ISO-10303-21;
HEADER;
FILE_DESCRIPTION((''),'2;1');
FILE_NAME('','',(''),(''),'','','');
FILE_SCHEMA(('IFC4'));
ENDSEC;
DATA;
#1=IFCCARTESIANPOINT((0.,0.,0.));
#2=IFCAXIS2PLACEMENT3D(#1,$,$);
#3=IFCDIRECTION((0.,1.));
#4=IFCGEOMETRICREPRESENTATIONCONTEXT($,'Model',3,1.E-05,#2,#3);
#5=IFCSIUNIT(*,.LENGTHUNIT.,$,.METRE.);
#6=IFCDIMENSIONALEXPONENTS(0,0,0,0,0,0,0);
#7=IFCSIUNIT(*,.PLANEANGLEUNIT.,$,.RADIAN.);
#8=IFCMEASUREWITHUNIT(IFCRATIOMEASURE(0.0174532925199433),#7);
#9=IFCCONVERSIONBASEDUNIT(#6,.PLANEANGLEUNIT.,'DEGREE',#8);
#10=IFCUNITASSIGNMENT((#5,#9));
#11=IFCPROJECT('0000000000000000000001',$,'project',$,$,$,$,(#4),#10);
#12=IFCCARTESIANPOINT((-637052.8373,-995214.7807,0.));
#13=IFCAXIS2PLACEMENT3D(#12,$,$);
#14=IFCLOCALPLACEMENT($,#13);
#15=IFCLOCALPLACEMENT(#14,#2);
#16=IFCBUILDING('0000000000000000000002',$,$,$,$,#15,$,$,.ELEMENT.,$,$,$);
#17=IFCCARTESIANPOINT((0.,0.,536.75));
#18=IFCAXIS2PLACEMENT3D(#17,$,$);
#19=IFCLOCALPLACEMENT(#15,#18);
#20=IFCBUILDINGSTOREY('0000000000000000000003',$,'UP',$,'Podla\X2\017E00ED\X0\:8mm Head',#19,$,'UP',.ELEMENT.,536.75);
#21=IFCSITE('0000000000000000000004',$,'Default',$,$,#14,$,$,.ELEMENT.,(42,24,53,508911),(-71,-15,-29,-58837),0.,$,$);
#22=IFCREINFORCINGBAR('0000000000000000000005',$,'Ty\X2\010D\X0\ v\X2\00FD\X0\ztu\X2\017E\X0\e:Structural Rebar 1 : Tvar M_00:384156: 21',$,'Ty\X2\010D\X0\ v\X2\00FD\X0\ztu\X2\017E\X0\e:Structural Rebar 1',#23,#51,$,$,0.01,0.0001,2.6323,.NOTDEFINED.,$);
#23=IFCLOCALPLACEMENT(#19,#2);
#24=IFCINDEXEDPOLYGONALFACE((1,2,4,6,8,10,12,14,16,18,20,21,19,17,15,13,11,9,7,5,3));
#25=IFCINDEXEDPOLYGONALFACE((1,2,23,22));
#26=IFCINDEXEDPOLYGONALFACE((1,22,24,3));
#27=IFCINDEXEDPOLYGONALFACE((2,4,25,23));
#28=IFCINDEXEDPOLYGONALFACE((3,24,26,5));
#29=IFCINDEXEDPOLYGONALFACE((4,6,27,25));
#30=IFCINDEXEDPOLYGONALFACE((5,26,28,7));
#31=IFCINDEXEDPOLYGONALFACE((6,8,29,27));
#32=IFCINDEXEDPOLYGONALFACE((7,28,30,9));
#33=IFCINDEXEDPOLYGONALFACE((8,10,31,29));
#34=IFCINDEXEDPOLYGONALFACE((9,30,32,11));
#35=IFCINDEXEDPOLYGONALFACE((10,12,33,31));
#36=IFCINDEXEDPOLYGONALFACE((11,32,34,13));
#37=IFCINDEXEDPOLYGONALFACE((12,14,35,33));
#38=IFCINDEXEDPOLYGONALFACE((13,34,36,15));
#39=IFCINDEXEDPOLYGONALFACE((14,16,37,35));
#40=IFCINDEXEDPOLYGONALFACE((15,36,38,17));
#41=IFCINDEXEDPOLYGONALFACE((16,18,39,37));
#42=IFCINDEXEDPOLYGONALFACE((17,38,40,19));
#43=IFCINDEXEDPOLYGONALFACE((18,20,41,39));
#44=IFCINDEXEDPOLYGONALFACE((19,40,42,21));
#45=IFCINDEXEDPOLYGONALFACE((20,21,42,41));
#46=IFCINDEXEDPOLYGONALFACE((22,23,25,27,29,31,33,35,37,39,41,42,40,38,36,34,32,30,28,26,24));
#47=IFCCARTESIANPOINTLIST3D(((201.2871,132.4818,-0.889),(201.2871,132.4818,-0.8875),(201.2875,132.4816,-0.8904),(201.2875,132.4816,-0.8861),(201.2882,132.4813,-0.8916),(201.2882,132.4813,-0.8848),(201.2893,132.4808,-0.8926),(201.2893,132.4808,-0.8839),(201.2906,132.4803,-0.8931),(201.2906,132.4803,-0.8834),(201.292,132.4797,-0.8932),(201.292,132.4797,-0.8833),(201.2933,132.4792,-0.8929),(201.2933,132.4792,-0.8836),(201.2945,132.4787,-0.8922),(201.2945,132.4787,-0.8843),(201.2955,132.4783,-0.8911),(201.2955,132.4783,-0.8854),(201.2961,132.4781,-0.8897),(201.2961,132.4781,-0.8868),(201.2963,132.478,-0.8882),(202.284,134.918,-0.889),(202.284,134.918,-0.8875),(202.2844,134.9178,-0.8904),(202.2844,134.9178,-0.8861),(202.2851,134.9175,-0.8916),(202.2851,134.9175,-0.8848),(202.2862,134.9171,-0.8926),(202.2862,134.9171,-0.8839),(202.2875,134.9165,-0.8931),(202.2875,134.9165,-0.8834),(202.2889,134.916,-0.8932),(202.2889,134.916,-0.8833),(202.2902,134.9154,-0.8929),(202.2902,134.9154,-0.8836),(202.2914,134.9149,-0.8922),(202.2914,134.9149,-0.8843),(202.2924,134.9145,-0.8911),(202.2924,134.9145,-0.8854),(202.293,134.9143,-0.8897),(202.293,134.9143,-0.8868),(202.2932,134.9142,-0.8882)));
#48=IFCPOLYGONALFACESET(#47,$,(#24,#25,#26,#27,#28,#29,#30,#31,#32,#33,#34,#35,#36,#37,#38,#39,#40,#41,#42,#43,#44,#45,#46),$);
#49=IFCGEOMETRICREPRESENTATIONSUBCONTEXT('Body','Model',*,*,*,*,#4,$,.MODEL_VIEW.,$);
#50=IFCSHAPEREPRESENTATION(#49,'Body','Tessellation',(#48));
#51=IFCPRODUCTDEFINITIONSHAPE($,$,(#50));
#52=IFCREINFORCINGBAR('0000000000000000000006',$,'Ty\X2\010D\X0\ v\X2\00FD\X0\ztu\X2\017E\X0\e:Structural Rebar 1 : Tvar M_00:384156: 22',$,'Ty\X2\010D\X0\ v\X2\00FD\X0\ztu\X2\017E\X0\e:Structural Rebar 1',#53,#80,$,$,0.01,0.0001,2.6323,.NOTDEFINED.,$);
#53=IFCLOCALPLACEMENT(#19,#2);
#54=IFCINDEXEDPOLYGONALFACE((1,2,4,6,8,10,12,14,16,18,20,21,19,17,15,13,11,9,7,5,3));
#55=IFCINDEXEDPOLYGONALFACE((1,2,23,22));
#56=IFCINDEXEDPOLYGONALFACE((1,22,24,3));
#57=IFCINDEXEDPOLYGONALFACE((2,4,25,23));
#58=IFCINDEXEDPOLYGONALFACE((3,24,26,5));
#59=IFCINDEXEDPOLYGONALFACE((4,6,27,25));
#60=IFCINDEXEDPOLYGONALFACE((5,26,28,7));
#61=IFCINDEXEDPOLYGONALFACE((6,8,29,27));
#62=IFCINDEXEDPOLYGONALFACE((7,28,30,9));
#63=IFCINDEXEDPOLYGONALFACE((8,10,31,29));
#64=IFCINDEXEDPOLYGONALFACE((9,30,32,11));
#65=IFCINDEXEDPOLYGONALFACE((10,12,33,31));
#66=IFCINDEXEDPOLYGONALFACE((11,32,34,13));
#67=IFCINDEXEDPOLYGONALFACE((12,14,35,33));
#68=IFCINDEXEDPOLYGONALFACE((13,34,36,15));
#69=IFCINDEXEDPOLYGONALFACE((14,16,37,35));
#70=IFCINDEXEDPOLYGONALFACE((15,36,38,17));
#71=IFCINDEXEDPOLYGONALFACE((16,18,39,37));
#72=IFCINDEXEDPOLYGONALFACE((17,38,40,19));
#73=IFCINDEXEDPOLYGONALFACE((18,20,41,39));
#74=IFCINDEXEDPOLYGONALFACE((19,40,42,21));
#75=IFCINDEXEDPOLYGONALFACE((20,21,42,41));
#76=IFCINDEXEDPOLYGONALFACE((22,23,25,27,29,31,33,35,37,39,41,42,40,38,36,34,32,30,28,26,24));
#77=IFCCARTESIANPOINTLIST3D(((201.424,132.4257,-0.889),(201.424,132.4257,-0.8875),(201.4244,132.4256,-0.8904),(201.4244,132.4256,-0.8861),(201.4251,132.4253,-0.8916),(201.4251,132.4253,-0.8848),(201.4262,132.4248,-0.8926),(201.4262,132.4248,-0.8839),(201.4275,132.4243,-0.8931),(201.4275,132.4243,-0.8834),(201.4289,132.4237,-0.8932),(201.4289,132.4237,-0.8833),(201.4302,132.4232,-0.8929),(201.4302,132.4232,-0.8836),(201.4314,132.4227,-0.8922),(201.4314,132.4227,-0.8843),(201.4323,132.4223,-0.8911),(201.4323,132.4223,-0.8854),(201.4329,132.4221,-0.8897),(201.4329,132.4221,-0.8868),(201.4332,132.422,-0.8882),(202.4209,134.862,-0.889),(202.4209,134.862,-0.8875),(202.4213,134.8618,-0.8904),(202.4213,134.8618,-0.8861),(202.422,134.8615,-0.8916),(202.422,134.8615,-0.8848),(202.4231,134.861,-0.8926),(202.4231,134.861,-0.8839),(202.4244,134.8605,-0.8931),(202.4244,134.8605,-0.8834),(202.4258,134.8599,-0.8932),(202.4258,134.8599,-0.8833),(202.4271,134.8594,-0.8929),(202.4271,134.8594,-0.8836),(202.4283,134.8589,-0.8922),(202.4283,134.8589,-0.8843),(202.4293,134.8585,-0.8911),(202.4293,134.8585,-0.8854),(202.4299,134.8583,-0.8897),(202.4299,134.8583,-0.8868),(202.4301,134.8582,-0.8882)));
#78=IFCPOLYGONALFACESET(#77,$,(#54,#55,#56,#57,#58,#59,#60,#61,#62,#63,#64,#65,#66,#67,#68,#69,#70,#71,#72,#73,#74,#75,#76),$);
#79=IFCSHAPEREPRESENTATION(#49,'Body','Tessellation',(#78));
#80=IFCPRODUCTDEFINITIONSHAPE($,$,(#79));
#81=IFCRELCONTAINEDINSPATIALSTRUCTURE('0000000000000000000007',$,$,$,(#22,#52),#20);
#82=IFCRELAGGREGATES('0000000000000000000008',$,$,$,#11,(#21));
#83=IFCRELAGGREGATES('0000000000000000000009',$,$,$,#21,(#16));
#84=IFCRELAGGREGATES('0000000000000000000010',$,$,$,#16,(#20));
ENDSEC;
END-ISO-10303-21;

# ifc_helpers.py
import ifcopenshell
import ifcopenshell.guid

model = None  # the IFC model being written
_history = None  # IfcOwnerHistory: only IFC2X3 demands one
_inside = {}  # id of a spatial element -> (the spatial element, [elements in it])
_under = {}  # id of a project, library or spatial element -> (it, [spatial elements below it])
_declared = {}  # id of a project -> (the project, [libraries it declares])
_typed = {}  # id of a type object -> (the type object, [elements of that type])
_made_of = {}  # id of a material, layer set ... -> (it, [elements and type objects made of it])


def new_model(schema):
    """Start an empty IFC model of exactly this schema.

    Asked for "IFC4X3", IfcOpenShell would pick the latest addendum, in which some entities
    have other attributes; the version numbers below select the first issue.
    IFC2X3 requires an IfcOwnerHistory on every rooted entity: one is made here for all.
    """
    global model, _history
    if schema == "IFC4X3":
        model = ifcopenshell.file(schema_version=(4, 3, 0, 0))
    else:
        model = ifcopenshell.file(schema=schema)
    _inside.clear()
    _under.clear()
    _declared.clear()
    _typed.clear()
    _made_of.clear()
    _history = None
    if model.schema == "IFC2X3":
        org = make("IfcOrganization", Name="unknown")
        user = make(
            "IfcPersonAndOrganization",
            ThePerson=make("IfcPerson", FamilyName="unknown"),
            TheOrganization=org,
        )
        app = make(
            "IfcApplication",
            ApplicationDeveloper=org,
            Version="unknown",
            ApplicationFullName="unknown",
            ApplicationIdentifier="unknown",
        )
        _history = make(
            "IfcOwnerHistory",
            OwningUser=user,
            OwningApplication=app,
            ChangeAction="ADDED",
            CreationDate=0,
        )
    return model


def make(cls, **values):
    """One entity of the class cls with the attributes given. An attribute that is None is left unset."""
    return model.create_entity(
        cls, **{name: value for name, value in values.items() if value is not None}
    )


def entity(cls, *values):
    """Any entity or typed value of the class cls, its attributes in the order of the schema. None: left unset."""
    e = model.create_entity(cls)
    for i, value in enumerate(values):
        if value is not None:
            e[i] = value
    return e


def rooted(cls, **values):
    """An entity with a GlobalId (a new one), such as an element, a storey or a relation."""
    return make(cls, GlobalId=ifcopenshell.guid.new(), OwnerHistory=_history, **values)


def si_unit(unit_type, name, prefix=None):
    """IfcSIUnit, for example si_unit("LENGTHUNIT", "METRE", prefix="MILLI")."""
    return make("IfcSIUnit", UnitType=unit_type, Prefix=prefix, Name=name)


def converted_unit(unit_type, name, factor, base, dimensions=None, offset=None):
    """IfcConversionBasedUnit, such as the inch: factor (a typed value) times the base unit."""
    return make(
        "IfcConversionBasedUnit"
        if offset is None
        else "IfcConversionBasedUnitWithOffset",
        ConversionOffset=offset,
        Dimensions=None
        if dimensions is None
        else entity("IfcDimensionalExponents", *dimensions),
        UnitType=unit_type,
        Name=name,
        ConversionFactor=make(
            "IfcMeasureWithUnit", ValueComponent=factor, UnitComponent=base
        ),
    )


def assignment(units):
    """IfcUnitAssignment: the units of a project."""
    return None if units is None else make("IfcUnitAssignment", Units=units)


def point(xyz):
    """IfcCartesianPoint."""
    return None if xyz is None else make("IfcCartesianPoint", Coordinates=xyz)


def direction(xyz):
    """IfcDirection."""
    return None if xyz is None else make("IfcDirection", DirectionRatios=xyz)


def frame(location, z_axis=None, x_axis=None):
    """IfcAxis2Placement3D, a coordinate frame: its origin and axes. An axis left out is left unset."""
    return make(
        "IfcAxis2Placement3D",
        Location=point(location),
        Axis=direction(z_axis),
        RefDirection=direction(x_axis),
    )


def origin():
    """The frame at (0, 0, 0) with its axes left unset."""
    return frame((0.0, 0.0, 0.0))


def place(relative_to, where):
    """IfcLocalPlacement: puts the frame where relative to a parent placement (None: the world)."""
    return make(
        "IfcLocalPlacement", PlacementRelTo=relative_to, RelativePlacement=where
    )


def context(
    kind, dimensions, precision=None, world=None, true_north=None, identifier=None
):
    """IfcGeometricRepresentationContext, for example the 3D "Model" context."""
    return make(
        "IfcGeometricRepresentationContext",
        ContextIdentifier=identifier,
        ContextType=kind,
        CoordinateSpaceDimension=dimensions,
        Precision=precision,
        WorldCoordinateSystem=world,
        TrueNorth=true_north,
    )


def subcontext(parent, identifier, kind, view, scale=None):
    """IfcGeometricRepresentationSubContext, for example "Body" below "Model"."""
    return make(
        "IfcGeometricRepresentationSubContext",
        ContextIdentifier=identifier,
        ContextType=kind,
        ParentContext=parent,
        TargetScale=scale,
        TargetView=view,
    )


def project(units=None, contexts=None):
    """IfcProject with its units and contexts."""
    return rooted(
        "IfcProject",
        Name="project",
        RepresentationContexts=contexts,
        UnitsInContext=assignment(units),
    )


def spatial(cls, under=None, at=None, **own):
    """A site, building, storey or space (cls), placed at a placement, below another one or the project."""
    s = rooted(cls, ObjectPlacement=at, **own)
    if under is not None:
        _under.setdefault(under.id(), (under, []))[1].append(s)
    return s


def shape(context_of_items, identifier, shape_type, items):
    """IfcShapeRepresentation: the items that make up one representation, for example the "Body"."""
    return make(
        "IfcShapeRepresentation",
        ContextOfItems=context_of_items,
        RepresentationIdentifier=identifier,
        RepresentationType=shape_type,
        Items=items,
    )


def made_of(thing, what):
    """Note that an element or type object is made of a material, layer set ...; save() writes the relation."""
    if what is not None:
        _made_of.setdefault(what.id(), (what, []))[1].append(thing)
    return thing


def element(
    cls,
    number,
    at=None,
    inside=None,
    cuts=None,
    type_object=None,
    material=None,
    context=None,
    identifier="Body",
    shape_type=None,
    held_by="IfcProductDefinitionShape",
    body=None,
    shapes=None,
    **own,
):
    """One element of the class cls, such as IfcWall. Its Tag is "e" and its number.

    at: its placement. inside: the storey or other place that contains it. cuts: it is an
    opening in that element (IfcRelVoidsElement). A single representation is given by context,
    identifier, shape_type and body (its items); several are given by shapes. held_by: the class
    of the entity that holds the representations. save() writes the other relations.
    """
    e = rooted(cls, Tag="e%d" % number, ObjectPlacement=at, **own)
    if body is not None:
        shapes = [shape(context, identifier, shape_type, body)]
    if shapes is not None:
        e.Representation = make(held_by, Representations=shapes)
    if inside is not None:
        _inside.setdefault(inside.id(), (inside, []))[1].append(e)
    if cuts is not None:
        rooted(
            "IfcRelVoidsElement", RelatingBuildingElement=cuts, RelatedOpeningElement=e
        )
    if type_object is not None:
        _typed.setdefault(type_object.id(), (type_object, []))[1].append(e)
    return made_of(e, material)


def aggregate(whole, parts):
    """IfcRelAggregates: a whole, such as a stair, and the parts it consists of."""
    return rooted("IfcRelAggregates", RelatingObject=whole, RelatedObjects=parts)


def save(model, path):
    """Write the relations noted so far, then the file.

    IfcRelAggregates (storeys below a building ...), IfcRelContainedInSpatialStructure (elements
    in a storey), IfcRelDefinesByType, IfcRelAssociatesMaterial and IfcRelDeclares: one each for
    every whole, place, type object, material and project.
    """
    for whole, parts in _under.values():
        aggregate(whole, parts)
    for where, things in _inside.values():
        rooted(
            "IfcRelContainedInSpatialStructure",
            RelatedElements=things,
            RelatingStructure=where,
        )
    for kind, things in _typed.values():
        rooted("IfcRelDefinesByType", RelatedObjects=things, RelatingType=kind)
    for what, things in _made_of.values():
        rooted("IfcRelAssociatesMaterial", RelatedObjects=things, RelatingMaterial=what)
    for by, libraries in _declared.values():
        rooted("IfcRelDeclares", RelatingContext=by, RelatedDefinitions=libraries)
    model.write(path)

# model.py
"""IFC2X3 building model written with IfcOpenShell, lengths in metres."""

from ifc_helpers import new_model, entity, si_unit, converted_unit, direction, frame, origin, place, context, subcontext, project, spatial, element, save


model = new_model("IFC2X3")

# Units and contexts
model_context = context("Model", 3, precision=1e-05, world=origin(), true_north=direction((0.0, 1.0)))
body_context = subcontext(model_context, "Body", "Model", "MODEL_VIEW")
ifc_project = project(units=[si_unit("LENGTHUNIT", "METRE"), converted_unit("PLANEANGLEUNIT", "DEGREE", entity("IfcRatioMeasure", 0.0174532925199433), si_unit("PLANEANGLEUNIT", "RADIAN"), dimensions=[0, 0, 0, 0, 0, 0, 0])], contexts=[model_context])

# Site, building, storey
site_placement = place(None, frame((-637052.8373, -995214.7807, 0.0)))
site = spatial("IfcSite", under=ifc_project, at=site_placement, Name="Default", CompositionType="ELEMENT", RefLatitude=(42, 24, 53, 508911), RefLongitude=(-71, -15, -29, -58837), RefElevation=0.0)
building_placement = place(site_placement, origin())
building = spatial("IfcBuilding", under=site, at=building_placement, CompositionType="ELEMENT")
storey_placement = place(building_placement, frame((0.0, 0.0, 536.75)))
storey = spatial("IfcBuildingStorey", under=building, at=storey_placement, Name="UP", ObjectType="Podlaží:8mm Head", LongName="UP", CompositionType="ELEMENT", Elevation=536.75)

# Reinforcing bars
reinforcing_bar_1_placement = place(storey_placement, origin())
element("IfcReinforcingBar", 1, at=reinforcing_bar_1_placement, inside=storey, Name="Tyč výztuže:Structural Rebar 1 : Tvar M_00:384156: 21", ObjectType="Tyč výztuže:Structural Rebar 1", BarLength=2.6323, BarRole="NOTDEFINED", CrossSectionArea=0.0001, NominalDiameter=0.01, context=body_context, shape_type="AdvancedSweptSolid", body=[
    entity("IfcSweptDiskSolid", entity("IfcCompositeCurve", [entity("IfcCompositeCurveSegment", "CONTINUOUS", True, entity("IfcPolyline", [entity("IfcCartesianPoint", [-202.2885, -134.9161, 0.8882]), entity("IfcCartesianPoint", [-201.2916, -132.4799, 0.8882])]))], False), 0.005, None, 0.0, 1.0),
])
reinforcing_bar_2_placement = place(storey_placement, origin())
element("IfcReinforcingBar", 2, at=reinforcing_bar_2_placement, inside=storey, Name="Tyč výztuže:Structural Rebar 1 : Tvar M_00:384156: 22", ObjectType="Tyč výztuže:Structural Rebar 1", BarLength=2.6323, BarRole="NOTDEFINED", CrossSectionArea=0.0001, NominalDiameter=0.01, context=body_context, shape_type="AdvancedSweptSolid", body=[
    entity("IfcSweptDiskSolid", entity("IfcCompositeCurve", [entity("IfcCompositeCurveSegment", "CONTINUOUS", True, entity("IfcPolyline", [entity("IfcCartesianPoint", [-202.4254, -134.8601, 0.8882]), entity("IfcCartesianPoint", [-201.4285, -132.4239, 0.8882])]))], False), 0.005, None, 0.0, 1.0),
])

save(model, "model.ifc")
